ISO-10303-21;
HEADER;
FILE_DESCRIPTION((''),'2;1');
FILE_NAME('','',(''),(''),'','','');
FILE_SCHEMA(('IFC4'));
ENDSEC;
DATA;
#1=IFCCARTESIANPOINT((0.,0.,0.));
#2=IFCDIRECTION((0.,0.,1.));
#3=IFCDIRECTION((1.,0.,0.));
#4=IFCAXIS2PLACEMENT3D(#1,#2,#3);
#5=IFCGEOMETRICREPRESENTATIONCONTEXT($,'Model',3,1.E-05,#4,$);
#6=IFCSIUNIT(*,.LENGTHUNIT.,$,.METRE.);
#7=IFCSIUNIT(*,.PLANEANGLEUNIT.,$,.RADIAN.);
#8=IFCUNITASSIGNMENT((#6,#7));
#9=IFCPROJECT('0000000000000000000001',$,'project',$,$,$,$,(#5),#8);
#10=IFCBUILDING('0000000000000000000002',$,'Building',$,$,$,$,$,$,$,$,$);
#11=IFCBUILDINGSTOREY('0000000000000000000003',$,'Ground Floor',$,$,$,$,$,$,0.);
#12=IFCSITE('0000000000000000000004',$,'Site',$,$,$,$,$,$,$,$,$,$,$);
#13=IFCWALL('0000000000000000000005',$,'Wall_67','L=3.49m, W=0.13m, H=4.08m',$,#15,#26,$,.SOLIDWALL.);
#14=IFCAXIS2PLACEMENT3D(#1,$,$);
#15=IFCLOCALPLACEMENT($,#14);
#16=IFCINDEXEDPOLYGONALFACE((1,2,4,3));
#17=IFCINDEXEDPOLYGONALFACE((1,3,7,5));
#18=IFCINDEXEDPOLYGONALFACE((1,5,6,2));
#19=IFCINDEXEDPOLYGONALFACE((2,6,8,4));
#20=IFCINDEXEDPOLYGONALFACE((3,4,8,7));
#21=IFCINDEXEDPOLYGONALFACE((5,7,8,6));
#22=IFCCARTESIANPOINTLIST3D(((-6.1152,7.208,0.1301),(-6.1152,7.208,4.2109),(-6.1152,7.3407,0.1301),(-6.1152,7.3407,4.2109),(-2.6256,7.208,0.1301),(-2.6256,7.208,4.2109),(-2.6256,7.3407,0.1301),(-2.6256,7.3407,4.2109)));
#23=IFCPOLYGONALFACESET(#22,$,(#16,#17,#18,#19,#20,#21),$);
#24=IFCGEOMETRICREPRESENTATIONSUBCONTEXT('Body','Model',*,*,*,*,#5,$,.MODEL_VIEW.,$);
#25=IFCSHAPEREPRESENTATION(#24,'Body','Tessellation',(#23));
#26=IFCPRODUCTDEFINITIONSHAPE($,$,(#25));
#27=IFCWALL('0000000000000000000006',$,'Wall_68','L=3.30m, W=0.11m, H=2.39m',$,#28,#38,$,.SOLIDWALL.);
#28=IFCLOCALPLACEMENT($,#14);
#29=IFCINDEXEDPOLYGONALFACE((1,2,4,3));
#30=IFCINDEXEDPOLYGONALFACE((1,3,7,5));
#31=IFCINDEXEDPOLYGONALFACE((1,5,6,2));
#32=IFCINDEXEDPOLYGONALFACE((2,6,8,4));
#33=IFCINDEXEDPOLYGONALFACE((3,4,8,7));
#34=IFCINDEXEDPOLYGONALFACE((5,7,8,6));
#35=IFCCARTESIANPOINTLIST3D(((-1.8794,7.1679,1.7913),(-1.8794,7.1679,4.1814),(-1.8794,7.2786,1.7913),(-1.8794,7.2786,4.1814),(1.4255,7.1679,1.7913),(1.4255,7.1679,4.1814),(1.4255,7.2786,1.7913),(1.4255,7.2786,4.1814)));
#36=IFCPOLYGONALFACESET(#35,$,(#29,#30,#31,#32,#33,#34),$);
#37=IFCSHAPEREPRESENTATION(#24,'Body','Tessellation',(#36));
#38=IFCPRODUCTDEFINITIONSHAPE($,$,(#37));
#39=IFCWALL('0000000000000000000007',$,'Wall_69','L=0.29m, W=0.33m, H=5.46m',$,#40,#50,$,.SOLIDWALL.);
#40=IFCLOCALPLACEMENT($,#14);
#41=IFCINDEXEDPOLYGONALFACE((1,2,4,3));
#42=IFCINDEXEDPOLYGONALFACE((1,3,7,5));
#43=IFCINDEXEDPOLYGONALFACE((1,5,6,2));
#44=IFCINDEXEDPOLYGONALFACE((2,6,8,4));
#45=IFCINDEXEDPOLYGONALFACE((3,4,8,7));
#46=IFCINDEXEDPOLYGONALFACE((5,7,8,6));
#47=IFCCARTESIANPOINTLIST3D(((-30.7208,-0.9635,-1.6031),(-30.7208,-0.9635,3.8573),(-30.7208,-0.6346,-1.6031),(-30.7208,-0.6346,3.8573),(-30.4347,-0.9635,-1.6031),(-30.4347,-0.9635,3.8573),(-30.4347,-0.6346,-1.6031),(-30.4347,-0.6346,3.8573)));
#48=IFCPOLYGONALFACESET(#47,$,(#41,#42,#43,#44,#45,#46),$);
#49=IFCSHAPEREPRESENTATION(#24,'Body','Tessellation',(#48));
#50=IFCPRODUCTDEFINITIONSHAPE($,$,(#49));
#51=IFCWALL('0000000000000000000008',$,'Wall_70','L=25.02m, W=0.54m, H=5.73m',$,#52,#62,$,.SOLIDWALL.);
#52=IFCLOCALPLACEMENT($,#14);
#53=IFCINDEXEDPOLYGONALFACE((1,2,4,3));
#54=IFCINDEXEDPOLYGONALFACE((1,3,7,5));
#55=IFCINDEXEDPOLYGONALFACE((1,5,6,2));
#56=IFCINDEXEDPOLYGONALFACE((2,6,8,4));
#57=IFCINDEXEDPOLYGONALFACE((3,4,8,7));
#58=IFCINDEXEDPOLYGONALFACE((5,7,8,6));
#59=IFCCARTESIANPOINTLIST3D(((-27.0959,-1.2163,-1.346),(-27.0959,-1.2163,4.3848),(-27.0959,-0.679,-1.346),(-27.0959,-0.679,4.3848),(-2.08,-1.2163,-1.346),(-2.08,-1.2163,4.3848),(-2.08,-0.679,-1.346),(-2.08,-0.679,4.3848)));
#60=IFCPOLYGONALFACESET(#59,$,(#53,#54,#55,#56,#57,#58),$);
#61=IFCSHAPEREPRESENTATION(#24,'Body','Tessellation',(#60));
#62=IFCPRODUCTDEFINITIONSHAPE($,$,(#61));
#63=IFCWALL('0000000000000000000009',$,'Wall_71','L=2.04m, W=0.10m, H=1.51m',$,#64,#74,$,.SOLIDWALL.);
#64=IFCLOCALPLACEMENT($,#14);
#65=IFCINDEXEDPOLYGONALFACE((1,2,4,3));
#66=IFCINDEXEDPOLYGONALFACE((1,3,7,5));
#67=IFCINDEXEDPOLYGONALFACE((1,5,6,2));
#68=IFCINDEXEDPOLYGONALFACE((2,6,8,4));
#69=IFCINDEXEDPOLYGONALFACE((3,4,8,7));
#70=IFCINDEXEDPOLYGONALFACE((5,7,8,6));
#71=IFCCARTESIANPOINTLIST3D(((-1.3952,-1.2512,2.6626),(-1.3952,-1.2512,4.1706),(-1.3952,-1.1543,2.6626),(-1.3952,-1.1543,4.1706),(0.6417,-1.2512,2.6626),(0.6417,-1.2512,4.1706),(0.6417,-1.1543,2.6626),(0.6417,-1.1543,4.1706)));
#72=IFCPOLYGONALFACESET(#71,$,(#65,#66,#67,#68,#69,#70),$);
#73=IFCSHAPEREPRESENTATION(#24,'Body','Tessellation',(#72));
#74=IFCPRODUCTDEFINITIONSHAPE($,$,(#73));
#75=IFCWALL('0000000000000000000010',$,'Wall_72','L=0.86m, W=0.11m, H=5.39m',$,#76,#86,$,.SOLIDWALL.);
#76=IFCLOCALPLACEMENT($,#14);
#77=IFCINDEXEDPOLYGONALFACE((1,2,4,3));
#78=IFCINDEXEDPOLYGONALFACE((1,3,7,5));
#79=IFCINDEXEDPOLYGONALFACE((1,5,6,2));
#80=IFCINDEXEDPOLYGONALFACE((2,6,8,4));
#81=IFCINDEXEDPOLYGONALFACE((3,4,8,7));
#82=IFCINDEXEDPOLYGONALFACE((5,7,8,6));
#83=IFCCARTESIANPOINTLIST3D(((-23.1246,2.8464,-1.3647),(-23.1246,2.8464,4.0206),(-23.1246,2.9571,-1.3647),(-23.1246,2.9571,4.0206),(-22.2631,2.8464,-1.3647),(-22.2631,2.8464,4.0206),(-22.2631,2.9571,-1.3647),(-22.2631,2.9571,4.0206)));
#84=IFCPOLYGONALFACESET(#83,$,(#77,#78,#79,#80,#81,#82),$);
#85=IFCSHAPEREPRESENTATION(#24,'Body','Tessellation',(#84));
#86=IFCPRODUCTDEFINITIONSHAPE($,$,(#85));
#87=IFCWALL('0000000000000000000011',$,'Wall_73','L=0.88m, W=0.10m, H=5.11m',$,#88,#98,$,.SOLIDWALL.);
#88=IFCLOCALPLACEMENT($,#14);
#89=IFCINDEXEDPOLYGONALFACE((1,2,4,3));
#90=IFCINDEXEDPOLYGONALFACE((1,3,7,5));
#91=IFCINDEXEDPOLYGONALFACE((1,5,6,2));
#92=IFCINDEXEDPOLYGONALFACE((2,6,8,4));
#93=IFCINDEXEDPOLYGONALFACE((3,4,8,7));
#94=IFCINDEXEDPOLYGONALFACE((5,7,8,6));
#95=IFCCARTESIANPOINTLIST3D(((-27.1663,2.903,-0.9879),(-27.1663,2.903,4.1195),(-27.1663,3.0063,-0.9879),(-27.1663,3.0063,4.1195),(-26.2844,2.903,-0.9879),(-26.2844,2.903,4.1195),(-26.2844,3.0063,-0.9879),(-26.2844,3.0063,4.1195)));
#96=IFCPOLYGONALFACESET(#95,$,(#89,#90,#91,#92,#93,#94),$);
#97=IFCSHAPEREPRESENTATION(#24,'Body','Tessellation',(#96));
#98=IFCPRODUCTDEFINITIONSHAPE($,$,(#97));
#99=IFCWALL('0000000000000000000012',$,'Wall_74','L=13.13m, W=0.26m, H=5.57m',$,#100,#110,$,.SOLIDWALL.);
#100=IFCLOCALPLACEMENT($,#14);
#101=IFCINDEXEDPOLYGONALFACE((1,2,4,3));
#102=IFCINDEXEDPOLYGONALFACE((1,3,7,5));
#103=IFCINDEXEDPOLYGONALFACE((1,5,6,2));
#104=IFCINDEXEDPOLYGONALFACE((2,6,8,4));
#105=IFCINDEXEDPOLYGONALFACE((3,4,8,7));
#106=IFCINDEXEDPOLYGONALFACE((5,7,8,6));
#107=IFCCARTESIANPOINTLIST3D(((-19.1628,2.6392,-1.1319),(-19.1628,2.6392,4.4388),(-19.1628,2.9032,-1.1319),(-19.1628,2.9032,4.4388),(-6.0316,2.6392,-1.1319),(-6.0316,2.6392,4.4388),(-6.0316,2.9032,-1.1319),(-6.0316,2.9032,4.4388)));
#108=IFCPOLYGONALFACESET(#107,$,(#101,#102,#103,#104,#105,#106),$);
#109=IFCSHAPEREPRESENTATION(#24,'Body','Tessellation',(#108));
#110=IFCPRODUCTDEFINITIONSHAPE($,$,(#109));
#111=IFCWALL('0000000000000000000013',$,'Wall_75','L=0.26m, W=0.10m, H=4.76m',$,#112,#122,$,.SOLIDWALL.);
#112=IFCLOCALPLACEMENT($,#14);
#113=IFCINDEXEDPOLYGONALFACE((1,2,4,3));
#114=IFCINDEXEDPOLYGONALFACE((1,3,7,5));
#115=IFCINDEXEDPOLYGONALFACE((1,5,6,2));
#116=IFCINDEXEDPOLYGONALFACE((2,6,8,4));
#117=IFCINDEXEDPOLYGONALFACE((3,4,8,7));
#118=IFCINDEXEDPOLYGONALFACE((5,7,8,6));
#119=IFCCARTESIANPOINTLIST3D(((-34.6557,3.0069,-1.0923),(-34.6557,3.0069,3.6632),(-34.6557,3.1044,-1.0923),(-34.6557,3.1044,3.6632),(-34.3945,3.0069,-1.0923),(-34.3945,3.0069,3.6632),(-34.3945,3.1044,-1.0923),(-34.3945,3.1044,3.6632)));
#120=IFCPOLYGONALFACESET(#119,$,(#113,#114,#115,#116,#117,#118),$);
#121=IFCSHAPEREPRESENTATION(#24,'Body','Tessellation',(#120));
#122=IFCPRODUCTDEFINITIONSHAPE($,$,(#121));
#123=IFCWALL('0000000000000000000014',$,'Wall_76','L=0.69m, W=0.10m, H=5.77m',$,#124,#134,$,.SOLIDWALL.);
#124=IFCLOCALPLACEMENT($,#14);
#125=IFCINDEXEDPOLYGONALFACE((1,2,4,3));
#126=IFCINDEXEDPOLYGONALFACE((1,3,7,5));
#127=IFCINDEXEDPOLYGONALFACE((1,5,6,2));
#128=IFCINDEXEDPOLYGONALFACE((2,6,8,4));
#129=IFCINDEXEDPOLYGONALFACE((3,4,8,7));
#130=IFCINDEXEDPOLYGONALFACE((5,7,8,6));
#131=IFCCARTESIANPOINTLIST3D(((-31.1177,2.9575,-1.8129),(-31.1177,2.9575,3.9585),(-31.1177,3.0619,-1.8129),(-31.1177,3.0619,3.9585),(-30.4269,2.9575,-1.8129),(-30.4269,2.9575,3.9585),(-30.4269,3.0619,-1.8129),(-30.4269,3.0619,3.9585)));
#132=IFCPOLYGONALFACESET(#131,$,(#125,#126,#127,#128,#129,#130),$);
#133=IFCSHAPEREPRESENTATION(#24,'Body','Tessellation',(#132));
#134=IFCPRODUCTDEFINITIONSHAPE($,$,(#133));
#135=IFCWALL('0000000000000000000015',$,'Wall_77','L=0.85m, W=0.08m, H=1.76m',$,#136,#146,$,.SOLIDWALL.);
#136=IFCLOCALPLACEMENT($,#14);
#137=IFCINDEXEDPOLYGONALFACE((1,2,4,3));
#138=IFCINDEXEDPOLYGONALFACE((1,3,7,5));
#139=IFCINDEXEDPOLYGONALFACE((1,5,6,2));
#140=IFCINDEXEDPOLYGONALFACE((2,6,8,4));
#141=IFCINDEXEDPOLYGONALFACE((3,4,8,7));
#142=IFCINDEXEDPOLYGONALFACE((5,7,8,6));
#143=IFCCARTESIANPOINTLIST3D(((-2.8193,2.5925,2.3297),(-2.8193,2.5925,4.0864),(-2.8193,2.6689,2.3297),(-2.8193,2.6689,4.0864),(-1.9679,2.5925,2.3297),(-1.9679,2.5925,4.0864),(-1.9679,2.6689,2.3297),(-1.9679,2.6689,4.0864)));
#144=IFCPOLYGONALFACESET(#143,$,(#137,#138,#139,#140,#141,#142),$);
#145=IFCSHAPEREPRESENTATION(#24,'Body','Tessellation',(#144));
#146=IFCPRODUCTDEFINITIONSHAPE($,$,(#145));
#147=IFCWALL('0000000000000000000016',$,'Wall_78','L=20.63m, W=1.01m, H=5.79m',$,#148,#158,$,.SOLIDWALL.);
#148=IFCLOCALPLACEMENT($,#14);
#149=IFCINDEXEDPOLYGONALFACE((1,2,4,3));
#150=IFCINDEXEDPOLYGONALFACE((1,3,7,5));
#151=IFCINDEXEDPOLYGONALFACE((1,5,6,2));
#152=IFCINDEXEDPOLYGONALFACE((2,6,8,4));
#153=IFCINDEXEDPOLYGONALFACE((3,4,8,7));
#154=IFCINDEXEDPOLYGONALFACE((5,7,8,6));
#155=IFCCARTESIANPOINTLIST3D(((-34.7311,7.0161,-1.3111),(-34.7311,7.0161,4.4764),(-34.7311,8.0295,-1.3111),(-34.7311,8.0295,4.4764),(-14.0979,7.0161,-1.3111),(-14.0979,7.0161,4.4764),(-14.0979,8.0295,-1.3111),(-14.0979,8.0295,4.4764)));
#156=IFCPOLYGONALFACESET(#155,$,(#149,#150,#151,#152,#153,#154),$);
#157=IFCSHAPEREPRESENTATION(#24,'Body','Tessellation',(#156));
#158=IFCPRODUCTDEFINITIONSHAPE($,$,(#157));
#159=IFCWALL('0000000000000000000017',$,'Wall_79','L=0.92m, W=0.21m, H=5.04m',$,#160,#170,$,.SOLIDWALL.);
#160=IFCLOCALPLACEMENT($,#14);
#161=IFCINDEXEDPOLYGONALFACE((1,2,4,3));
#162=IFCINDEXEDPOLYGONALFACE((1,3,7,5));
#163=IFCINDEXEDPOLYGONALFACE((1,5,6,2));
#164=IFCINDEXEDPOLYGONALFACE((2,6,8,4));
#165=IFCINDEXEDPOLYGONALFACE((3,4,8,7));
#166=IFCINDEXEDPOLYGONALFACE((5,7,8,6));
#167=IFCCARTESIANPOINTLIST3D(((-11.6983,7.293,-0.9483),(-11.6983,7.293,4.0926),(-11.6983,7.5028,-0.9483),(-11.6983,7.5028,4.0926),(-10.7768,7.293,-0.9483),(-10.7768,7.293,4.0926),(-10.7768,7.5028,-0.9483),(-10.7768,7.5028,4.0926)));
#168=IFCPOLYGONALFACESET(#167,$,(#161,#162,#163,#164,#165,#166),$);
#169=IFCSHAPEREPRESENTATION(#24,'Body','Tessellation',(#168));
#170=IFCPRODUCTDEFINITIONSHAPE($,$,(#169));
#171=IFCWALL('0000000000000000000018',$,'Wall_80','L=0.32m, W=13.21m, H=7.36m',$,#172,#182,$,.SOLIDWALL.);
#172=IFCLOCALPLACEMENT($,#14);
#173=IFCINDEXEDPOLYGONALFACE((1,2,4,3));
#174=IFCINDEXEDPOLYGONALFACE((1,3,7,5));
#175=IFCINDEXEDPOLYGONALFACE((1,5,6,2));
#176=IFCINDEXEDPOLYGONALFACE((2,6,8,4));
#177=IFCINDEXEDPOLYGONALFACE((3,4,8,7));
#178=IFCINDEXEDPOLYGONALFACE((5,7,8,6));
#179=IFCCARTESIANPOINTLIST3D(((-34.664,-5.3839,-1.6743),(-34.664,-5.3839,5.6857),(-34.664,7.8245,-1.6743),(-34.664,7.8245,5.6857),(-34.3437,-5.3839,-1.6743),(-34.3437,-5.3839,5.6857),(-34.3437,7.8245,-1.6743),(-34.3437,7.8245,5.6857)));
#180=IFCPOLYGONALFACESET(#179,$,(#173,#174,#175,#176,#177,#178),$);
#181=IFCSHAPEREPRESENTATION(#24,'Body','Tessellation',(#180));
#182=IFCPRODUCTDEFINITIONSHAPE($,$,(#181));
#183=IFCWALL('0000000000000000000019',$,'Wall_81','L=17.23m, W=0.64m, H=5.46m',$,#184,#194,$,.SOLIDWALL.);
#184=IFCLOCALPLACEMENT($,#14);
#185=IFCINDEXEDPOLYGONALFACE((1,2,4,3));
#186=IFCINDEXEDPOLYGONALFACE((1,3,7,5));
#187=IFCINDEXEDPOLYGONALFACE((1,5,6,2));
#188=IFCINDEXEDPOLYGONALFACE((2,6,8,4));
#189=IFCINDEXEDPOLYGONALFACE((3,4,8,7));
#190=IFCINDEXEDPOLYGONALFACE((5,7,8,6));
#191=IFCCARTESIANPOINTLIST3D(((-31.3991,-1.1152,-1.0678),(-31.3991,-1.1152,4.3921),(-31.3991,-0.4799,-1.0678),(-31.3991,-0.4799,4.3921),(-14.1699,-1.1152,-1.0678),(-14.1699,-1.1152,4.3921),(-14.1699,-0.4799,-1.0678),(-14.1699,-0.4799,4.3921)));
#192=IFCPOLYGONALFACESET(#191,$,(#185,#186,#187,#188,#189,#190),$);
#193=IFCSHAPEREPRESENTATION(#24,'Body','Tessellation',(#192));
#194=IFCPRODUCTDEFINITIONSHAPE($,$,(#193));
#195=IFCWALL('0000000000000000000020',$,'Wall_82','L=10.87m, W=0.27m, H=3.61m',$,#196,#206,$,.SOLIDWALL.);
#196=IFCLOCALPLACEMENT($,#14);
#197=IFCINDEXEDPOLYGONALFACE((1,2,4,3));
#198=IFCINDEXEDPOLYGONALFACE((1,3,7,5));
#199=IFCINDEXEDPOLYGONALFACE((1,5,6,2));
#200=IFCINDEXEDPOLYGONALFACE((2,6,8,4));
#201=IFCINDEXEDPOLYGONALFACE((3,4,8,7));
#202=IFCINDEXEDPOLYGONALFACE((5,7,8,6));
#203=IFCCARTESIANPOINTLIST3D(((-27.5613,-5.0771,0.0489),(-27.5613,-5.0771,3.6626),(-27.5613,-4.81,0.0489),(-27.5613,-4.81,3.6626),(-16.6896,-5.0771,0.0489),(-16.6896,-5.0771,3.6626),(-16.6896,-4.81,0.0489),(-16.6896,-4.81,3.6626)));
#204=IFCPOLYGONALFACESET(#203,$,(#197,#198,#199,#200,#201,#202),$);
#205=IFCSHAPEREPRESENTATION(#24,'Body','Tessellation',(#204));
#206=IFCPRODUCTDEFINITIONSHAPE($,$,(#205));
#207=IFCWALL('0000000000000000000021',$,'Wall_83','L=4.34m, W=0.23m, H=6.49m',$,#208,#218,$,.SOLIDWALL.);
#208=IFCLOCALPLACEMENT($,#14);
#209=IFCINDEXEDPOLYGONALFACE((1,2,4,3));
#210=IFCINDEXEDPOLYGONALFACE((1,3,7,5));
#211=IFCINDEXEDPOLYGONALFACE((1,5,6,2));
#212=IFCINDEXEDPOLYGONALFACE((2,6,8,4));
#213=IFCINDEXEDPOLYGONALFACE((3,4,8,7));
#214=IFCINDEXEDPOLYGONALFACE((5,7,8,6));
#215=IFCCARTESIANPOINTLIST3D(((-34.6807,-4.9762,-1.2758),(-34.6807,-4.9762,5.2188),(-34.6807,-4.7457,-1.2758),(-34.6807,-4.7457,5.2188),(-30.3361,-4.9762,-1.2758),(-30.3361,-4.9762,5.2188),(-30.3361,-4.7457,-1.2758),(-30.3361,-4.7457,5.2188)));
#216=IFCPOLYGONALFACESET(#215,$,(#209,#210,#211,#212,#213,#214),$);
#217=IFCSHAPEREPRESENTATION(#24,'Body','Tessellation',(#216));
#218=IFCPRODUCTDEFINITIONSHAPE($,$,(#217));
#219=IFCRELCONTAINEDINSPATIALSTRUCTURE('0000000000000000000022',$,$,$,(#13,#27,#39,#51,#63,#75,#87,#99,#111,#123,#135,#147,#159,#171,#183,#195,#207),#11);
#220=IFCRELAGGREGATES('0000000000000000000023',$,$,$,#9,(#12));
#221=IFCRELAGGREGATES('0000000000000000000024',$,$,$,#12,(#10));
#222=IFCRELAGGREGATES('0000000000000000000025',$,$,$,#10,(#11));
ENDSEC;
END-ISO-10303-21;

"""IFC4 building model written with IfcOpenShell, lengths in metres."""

from ifc_helpers import new_model, si_unit, frame, origin_with_axes, origin_2d, context, subcontext, project, spatial, rectangle, extrude, element, save


model = new_model("IFC4")

# Units and contexts
model_context = context("Model", 3, precision=1e-05, world=origin_with_axes())
body_context = subcontext(model_context, "Body", "Model", "MODEL_VIEW")
ifc_project = project(units=[si_unit("LENGTHUNIT", "METRE"), si_unit("PLANEANGLEUNIT", "RADIAN")], contexts=[model_context])

# Site, building, storey
site = spatial("IfcSite", under=ifc_project, Name="Site")
building = spatial("IfcBuilding", under=site, Name="Building")
storey = spatial("IfcBuildingStorey", under=building, Name="Ground Floor", Elevation=0.0)

# Walls
element("IfcWall", 1, inside=storey, Name="Wall_67", Description="L=3.49m, W=0.13m, H=4.08m", PredefinedType="SOLIDWALL", context=body_context, shape_type="SweptSolid", body=[
    extrude(rectangle(XDim=3.4897, YDim=0.1327, at=origin_2d()), frame((-4.3704, 7.2743, 0.1301), z_axis=(0.0, 0.0, 1.0), x_axis=(1.0, 0.0, 0.0)), (0.0, 0.0, 1.0), 4.0809),
])
element("IfcWall", 2, inside=storey, Name="Wall_68", Description="L=3.30m, W=0.11m, H=2.39m", PredefinedType="SOLIDWALL", context=body_context, shape_type="SweptSolid", body=[
    extrude(rectangle(XDim=3.305, YDim=0.1107, at=origin_2d()), frame((-0.227, 7.2232, 1.7913), z_axis=(0.0, 0.0, 1.0), x_axis=(1.0, 0.0, 0.0)), (0.0, 0.0, 1.0), 2.3901),
])
element("IfcWall", 3, inside=storey, Name="Wall_69", Description="L=0.29m, W=0.33m, H=5.46m", PredefinedType="SOLIDWALL", context=body_context, shape_type="SweptSolid", body=[
    extrude(rectangle(XDim=0.2861, YDim=0.3289, at=origin_2d()), frame((-30.5778, -0.799, -1.6031), z_axis=(0.0, 0.0, 1.0), x_axis=(1.0, 0.0, 0.0)), (0.0, 0.0, 1.0), 5.4605),
])
element("IfcWall", 4, inside=storey, Name="Wall_70", Description="L=25.02m, W=0.54m, H=5.73m", PredefinedType="SOLIDWALL", context=body_context, shape_type="SweptSolid", body=[
    extrude(rectangle(XDim=25.0159, YDim=0.5374, at=origin_2d()), frame((-14.5879, -0.9476, -1.346), z_axis=(0.0, 0.0, 1.0), x_axis=(1.0, 0.0, 0.0)), (0.0, 0.0, 1.0), 5.7308),
])
element("IfcWall", 5, inside=storey, Name="Wall_71", Description="L=2.04m, W=0.10m, H=1.51m", PredefinedType="SOLIDWALL", context=body_context, shape_type="SweptSolid", body=[
    extrude(rectangle(XDim=2.037, YDim=0.097, at=origin_2d()), frame((-0.3768, -1.2027, 2.6626), z_axis=(0.0, 0.0, 1.0), x_axis=(1.0, 0.0, 0.0)), (0.0, 0.0, 1.0), 1.5081),
])
element("IfcWall", 6, inside=storey, Name="Wall_72", Description="L=0.86m, W=0.11m, H=5.39m", PredefinedType="SOLIDWALL", context=body_context, shape_type="SweptSolid", body=[
    extrude(rectangle(XDim=0.8615, YDim=0.1107, at=origin_2d()), frame((-22.6939, 2.9017, -1.3647), z_axis=(0.0, 0.0, 1.0), x_axis=(1.0, 0.0, 0.0)), (0.0, 0.0, 1.0), 5.3853),
])
element("IfcWall", 7, inside=storey, Name="Wall_73", Description="L=0.88m, W=0.10m, H=5.11m", PredefinedType="SOLIDWALL", context=body_context, shape_type="SweptSolid", body=[
    extrude(rectangle(XDim=0.8819, YDim=0.1033, at=origin_2d()), frame((-26.7254, 2.9547, -0.9879), z_axis=(0.0, 0.0, 1.0), x_axis=(1.0, 0.0, 0.0)), (0.0, 0.0, 1.0), 5.1075),
])
element("IfcWall", 8, inside=storey, Name="Wall_74", Description="L=13.13m, W=0.26m, H=5.57m", PredefinedType="SOLIDWALL", context=body_context, shape_type="SweptSolid", body=[
    extrude(rectangle(XDim=13.1312, YDim=0.264, at=origin_2d()), frame((-12.5972, 2.7712, -1.1319), z_axis=(0.0, 0.0, 1.0), x_axis=(1.0, 0.0, 0.0)), (0.0, 0.0, 1.0), 5.5707),
])
element("IfcWall", 9, inside=storey, Name="Wall_75", Description="L=0.26m, W=0.10m, H=4.76m", PredefinedType="SOLIDWALL", context=body_context, shape_type="SweptSolid", body=[
    extrude(rectangle(XDim=0.2612, YDim=0.0975, at=origin_2d()), frame((-34.5251, 3.0556, -1.0923), z_axis=(0.0, 0.0, 1.0), x_axis=(1.0, 0.0, 0.0)), (0.0, 0.0, 1.0), 4.7555),
])
element("IfcWall", 10, inside=storey, Name="Wall_76", Description="L=0.69m, W=0.10m, H=5.77m", PredefinedType="SOLIDWALL", context=body_context, shape_type="SweptSolid", body=[
    extrude(rectangle(XDim=0.6907, YDim=0.1044, at=origin_2d()), frame((-30.7723, 3.0097, -1.8129), z_axis=(0.0, 0.0, 1.0), x_axis=(1.0, 0.0, 0.0)), (0.0, 0.0, 1.0), 5.7715),
])
element("IfcWall", 11, inside=storey, Name="Wall_77", Description="L=0.85m, W=0.08m, H=1.76m", PredefinedType="SOLIDWALL", context=body_context, shape_type="SweptSolid", body=[
    extrude(rectangle(XDim=0.8514, YDim=0.0764, at=origin_2d()), frame((-2.3936, 2.6307, 2.3297), z_axis=(0.0, 0.0, 1.0), x_axis=(1.0, 0.0, 0.0)), (0.0, 0.0, 1.0), 1.7568),
])
element("IfcWall", 12, inside=storey, Name="Wall_78", Description="L=20.63m, W=1.01m, H=5.79m", PredefinedType="SOLIDWALL", context=body_context, shape_type="SweptSolid", body=[
    extrude(rectangle(XDim=20.6332, YDim=1.0133, at=origin_2d()), frame((-24.4145, 7.5228, -1.3111), z_axis=(0.0, 0.0, 1.0), x_axis=(1.0, 0.0, 0.0)), (0.0, 0.0, 1.0), 5.7875),
])
element("IfcWall", 13, inside=storey, Name="Wall_79", Description="L=0.92m, W=0.21m, H=5.04m", PredefinedType="SOLIDWALL", context=body_context, shape_type="SweptSolid", body=[
    extrude(rectangle(XDim=0.9215, YDim=0.2097, at=origin_2d()), frame((-11.2375, 7.3979, -0.9483), z_axis=(0.0, 0.0, 1.0), x_axis=(1.0, 0.0, 0.0)), (0.0, 0.0, 1.0), 5.0409),
])
element("IfcWall", 14, inside=storey, Name="Wall_80", Description="L=0.32m, W=13.21m, H=7.36m", PredefinedType="SOLIDWALL", context=body_context, shape_type="SweptSolid", body=[
    extrude(rectangle(XDim=0.3203, YDim=13.2084, at=origin_2d()), frame((-34.5038, 1.2203, -1.6743), z_axis=(0.0, 0.0, 1.0), x_axis=(1.0, 0.0, 0.0)), (0.0, 0.0, 1.0), 7.36),
])
element("IfcWall", 15, inside=storey, Name="Wall_81", Description="L=17.23m, W=0.64m, H=5.46m", PredefinedType="SOLIDWALL", context=body_context, shape_type="SweptSolid", body=[
    extrude(rectangle(XDim=17.2292, YDim=0.6353, at=origin_2d()), frame((-22.7845, -0.7975, -1.0678), z_axis=(0.0, 0.0, 1.0), x_axis=(1.0, 0.0, 0.0)), (0.0, 0.0, 1.0), 5.4599),
])
element("IfcWall", 16, inside=storey, Name="Wall_82", Description="L=10.87m, W=0.27m, H=3.61m", PredefinedType="SOLIDWALL", context=body_context, shape_type="SweptSolid", body=[
    extrude(rectangle(XDim=10.8717, YDim=0.267, at=origin_2d()), frame((-22.1254, -4.9436, 0.0489), z_axis=(0.0, 0.0, 1.0), x_axis=(1.0, 0.0, 0.0)), (0.0, 0.0, 1.0), 3.6137),
])
element("IfcWall", 17, inside=storey, Name="Wall_83", Description="L=4.34m, W=0.23m, H=6.49m", PredefinedType="SOLIDWALL", context=body_context, shape_type="SweptSolid", body=[
    extrude(rectangle(XDim=4.3446, YDim=0.2305, at=origin_2d()), frame((-32.5084, -4.861, -1.2758), z_axis=(0.0, 0.0, 1.0), x_axis=(1.0, 0.0, 0.0)), (0.0, 0.0, 1.0), 6.4946),
])

save(model, "model.ifc")
